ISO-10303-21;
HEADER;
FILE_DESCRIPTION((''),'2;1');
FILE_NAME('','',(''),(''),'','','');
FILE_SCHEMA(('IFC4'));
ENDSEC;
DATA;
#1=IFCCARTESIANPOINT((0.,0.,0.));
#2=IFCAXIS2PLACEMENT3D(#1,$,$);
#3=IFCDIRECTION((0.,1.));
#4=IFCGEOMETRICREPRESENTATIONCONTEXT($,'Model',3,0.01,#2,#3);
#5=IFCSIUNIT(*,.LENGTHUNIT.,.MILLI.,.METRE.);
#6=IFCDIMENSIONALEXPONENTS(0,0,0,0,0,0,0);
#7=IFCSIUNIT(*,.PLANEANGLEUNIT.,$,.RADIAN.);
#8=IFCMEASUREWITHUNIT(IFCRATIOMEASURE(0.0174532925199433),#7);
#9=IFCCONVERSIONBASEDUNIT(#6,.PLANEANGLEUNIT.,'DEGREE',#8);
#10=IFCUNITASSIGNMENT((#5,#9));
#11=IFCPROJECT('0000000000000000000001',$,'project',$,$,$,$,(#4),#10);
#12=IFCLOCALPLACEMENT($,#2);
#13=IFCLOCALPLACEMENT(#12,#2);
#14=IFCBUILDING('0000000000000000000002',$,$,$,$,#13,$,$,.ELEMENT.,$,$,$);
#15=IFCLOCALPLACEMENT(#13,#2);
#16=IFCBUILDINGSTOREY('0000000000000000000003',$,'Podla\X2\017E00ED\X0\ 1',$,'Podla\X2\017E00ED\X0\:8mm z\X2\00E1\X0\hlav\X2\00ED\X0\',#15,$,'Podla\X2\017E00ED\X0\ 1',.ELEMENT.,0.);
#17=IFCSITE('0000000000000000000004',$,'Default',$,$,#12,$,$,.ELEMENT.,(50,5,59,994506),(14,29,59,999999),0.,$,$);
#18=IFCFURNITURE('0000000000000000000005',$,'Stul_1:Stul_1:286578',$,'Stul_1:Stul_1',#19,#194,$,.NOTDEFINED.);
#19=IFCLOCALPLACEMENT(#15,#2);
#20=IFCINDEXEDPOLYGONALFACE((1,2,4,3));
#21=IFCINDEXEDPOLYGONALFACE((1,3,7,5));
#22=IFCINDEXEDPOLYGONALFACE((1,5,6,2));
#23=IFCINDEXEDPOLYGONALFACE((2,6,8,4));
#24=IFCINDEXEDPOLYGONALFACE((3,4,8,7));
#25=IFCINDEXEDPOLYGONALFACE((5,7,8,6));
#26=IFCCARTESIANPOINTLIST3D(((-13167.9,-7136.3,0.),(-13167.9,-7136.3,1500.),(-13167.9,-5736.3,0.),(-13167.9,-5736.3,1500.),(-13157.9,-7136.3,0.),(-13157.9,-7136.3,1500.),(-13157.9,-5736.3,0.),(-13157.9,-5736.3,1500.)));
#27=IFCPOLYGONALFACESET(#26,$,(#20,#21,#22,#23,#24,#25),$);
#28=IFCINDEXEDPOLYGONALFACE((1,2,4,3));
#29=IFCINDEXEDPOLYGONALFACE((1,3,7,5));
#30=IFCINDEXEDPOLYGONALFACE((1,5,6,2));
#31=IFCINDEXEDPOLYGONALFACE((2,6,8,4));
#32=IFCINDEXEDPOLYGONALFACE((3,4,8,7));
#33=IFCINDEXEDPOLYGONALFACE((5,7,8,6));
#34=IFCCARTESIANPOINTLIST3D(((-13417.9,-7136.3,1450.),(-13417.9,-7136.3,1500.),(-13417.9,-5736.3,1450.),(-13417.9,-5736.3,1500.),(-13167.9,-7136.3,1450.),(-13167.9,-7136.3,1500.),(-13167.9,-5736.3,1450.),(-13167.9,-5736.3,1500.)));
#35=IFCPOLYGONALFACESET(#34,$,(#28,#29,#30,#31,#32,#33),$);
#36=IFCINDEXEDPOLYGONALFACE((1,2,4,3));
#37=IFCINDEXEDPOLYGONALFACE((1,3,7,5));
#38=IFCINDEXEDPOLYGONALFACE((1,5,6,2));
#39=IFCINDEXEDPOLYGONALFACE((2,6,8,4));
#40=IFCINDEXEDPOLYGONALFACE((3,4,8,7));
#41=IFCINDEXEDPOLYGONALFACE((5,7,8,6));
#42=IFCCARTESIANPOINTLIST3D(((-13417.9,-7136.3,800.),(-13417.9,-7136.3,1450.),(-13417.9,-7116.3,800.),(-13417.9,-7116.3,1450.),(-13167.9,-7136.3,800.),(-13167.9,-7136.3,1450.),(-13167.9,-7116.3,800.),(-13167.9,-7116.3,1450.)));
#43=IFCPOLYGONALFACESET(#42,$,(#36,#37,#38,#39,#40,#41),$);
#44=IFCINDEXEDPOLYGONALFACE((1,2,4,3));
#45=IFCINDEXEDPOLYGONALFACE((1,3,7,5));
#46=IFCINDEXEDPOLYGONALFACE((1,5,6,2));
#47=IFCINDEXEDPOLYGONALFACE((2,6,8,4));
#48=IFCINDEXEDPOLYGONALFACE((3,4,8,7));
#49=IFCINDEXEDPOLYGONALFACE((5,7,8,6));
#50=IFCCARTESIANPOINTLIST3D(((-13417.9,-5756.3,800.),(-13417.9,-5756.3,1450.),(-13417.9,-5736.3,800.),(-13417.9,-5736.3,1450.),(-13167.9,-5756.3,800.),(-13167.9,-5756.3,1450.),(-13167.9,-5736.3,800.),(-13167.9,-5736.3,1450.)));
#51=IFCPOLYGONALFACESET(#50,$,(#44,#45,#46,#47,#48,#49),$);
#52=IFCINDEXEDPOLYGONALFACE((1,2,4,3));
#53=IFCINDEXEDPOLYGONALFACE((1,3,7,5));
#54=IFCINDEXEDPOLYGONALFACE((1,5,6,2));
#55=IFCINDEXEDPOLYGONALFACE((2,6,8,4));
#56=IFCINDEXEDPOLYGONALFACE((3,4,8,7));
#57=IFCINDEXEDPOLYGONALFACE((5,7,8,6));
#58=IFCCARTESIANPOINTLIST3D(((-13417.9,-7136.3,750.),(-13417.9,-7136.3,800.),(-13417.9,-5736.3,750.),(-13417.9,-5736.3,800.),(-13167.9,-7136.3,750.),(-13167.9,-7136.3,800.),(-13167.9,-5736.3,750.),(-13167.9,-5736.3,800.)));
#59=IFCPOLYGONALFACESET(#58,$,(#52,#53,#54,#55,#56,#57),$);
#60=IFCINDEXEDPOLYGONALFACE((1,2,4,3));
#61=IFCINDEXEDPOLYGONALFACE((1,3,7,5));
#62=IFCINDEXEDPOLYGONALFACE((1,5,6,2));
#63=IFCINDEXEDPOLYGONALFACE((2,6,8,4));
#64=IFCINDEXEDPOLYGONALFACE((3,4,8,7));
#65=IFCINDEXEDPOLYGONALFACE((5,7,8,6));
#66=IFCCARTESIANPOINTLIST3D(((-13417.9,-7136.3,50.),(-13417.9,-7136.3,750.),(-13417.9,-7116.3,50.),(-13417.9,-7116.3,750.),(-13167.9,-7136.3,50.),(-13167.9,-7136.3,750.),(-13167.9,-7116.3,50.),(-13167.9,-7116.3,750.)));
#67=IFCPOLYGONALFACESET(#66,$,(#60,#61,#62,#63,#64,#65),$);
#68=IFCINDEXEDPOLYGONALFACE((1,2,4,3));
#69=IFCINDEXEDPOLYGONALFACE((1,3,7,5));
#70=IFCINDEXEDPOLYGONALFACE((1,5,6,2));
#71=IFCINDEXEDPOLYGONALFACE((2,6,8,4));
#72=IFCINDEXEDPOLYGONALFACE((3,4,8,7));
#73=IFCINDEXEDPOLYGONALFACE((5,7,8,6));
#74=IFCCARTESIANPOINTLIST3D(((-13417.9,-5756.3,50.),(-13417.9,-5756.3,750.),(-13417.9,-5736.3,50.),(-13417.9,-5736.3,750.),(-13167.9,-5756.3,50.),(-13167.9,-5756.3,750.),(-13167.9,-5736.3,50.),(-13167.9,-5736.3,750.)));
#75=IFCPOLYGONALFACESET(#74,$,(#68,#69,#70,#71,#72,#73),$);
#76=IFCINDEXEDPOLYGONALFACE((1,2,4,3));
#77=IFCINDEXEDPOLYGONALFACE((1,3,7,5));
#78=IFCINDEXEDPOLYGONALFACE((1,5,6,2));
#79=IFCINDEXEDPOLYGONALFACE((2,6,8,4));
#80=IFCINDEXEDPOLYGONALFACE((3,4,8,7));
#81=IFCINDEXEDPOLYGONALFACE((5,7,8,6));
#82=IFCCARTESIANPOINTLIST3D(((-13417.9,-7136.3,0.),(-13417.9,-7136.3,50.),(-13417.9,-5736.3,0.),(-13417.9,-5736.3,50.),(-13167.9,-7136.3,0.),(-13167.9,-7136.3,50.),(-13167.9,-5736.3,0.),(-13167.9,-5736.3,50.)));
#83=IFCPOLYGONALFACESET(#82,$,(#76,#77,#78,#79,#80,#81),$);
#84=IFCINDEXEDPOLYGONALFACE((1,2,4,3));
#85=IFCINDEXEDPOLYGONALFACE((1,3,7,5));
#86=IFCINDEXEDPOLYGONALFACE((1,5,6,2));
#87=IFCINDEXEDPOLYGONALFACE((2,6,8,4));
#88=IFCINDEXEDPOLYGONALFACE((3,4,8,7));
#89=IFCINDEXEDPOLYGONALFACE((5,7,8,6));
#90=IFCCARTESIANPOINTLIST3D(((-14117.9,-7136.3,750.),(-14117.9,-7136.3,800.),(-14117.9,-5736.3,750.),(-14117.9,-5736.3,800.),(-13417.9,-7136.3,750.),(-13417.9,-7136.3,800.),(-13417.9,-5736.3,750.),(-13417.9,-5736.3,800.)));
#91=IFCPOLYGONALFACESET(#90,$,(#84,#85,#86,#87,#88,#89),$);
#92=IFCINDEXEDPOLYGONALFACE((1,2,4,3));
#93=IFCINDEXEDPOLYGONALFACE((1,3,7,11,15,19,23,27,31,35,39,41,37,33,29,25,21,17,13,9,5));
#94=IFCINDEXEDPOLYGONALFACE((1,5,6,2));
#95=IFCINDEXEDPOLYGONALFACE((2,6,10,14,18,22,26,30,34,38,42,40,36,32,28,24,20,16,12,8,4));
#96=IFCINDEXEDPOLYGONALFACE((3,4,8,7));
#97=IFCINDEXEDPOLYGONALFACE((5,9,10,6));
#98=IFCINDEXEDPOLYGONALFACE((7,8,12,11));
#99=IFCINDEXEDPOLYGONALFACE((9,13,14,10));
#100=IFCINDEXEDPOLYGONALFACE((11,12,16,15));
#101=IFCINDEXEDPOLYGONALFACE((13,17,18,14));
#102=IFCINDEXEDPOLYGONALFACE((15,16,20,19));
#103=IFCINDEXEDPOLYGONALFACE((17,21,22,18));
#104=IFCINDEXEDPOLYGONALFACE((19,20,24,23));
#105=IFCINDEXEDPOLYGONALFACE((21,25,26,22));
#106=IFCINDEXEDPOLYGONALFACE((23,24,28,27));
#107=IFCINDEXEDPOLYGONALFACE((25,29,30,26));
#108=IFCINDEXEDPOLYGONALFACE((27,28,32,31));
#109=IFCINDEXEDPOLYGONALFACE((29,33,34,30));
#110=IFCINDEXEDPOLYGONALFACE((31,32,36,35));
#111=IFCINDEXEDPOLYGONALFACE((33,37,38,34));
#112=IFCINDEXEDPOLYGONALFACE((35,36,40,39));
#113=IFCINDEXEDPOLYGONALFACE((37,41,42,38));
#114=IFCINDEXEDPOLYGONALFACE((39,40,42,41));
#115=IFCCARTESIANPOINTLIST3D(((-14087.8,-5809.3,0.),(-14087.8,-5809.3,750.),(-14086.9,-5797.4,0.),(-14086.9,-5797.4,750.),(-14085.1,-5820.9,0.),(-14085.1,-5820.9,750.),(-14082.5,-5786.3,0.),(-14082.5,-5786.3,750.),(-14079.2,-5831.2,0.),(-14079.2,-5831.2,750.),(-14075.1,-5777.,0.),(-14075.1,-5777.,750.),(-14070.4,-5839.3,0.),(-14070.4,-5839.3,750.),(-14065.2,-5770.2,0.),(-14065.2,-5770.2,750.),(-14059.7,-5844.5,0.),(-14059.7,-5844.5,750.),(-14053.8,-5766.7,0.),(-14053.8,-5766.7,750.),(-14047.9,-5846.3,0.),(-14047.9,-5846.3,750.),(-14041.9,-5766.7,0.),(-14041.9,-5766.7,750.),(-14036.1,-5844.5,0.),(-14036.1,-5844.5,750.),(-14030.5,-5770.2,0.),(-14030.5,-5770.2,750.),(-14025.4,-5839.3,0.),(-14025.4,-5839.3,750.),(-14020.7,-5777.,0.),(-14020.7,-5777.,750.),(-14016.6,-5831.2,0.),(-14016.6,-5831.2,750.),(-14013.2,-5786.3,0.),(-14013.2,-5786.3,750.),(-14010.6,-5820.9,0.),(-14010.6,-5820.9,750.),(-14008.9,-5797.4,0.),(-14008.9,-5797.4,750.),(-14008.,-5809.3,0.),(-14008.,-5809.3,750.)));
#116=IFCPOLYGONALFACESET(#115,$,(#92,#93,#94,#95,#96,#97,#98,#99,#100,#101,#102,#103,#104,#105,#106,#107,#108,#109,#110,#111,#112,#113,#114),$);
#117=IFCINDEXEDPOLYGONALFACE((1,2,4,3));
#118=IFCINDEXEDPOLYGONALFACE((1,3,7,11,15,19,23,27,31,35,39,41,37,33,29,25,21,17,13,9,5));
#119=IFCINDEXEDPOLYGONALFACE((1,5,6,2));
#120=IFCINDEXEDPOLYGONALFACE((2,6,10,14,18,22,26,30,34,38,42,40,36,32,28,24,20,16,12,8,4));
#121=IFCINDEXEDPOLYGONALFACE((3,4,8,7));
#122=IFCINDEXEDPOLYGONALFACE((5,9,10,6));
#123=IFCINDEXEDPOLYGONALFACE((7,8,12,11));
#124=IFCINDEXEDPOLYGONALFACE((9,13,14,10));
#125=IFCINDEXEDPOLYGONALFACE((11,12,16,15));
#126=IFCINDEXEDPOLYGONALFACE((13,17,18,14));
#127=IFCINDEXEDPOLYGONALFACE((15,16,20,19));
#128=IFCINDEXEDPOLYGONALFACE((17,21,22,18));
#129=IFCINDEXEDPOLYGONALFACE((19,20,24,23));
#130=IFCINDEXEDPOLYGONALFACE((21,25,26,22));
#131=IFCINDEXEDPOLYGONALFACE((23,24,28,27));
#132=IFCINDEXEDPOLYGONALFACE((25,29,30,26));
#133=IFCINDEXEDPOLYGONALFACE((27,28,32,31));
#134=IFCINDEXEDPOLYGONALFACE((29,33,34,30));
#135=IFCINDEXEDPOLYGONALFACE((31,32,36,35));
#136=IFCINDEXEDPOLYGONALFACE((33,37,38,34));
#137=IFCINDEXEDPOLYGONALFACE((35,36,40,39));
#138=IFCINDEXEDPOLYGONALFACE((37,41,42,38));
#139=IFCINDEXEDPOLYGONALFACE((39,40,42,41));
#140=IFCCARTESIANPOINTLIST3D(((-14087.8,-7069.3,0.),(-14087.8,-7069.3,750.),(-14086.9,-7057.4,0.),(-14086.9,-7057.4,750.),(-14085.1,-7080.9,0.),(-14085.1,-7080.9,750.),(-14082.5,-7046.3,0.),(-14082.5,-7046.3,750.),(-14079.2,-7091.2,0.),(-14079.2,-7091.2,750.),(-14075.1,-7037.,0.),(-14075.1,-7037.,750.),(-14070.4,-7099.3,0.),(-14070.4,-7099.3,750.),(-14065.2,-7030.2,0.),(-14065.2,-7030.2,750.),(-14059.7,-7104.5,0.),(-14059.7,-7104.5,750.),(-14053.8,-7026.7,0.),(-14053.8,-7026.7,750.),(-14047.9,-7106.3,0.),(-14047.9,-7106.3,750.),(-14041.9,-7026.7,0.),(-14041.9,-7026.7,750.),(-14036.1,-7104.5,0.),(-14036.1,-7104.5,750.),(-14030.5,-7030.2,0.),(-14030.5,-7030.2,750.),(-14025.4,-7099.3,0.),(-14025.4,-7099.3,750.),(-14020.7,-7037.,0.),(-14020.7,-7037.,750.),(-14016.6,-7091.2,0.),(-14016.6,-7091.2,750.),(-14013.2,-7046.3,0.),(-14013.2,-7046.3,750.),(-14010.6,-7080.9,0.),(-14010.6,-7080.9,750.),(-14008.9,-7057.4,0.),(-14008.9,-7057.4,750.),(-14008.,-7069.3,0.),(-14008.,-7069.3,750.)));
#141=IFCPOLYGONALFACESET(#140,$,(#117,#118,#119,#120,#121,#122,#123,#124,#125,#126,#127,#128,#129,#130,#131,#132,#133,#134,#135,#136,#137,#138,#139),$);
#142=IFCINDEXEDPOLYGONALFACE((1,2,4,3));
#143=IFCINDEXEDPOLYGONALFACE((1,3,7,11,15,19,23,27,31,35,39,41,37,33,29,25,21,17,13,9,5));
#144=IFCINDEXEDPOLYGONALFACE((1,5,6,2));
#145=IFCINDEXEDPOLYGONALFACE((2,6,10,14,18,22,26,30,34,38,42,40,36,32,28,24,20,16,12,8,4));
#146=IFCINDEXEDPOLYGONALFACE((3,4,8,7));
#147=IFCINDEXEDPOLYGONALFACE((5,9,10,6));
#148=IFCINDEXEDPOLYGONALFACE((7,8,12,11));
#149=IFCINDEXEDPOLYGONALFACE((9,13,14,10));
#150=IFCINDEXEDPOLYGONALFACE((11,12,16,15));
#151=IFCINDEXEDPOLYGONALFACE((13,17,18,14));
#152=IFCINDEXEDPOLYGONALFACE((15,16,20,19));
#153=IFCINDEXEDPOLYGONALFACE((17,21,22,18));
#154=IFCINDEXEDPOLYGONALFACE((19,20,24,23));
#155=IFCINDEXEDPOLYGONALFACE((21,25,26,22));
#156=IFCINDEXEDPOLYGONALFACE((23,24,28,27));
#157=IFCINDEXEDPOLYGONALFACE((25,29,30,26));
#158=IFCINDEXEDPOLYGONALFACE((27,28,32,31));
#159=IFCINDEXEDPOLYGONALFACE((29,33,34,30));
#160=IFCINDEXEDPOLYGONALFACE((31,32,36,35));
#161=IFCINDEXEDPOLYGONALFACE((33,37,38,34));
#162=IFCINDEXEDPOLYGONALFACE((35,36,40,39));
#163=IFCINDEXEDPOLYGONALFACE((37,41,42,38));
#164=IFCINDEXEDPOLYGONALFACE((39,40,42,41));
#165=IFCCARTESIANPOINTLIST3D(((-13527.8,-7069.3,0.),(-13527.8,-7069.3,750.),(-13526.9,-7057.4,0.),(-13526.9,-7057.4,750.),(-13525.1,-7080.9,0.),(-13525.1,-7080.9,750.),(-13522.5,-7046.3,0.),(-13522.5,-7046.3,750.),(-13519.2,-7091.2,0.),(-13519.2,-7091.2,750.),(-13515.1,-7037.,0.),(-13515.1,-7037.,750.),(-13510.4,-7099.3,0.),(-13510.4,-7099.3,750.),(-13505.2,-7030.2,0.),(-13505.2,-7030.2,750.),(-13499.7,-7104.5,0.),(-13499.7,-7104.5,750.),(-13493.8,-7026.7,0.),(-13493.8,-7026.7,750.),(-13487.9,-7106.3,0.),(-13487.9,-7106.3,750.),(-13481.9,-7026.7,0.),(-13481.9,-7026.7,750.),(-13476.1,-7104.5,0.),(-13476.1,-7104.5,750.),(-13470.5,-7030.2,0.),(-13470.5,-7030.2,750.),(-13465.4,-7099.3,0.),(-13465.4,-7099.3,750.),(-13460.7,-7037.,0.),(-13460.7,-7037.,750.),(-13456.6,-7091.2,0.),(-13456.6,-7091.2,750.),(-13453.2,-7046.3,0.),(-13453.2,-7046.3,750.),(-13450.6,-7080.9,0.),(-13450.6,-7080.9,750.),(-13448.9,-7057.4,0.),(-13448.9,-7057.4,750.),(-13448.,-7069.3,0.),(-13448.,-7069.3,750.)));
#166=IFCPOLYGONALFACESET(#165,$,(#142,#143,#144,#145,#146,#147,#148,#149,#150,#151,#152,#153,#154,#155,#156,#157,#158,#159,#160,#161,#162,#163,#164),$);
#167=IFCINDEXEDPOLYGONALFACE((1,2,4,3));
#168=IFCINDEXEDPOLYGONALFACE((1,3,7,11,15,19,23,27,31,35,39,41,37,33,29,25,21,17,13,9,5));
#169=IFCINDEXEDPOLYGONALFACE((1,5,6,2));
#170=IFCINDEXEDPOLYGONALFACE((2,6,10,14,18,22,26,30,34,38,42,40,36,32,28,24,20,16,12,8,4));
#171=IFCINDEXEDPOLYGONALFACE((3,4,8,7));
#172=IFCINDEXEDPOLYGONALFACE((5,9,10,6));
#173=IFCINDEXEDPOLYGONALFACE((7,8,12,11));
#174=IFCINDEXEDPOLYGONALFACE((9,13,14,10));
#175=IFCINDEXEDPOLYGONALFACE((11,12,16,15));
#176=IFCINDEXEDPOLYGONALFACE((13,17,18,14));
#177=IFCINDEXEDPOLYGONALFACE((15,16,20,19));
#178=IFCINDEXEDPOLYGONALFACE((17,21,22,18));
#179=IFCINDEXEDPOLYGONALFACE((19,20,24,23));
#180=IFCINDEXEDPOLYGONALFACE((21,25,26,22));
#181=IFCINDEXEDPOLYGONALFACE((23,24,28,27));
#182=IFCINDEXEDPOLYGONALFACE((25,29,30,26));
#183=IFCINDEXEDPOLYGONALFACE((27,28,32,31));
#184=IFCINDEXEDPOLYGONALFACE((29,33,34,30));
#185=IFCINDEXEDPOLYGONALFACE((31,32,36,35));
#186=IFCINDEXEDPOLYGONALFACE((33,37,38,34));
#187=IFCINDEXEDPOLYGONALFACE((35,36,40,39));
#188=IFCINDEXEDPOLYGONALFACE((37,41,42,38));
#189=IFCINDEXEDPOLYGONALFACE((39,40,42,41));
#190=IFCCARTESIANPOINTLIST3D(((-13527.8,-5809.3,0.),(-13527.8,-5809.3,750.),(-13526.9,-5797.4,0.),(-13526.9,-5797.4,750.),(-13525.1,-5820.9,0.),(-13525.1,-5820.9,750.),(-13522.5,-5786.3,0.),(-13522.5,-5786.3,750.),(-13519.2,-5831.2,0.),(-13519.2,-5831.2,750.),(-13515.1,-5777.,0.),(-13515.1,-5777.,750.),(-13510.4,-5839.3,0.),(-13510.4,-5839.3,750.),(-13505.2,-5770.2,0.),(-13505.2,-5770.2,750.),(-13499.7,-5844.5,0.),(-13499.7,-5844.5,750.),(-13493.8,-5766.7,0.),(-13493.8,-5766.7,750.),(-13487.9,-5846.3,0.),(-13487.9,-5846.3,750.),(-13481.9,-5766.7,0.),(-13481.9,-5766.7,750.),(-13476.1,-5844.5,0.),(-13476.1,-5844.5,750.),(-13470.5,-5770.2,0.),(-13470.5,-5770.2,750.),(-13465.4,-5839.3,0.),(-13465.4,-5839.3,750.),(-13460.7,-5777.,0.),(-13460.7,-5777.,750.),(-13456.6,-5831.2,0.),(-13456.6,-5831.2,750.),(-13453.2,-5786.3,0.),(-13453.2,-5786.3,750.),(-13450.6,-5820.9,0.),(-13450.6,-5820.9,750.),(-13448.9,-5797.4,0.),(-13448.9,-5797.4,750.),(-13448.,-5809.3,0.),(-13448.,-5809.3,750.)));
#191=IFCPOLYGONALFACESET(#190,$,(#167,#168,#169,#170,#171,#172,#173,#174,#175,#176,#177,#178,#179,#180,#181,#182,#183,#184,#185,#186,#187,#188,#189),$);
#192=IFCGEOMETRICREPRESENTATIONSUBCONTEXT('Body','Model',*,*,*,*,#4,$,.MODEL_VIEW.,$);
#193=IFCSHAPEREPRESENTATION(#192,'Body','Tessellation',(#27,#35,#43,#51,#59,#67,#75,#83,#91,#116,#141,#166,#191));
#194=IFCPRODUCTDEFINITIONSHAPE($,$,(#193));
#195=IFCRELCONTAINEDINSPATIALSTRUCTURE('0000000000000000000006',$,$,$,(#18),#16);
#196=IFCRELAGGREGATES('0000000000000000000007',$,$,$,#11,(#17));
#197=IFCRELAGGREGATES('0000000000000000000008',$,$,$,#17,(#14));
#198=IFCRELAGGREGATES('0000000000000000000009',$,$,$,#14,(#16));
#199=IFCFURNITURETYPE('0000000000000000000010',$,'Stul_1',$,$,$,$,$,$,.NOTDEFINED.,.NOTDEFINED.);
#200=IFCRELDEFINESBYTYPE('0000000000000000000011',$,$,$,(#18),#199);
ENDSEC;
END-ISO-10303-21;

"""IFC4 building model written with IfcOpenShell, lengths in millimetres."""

from ifc_helpers import new_model, entity, si_unit, converted_unit, direction, frame, frame_2d, origin, origin_2d_with_axis, place, context, subcontext, project, spatial, rectangle, circle, extrude, source, transform, mapped, type_object, type_shapes, element, save


model = new_model("IFC4")

# Units and contexts
model_context = context("Model", 3, precision=0.01, world=origin(), true_north=direction((0.0, 1.0)))
body_context = subcontext(model_context, "Body", "Model", "MODEL_VIEW")
ifc_project = project(units=[si_unit("LENGTHUNIT", "METRE", prefix="MILLI"), converted_unit("PLANEANGLEUNIT", "DEGREE", entity("IfcRatioMeasure", 0.0174532925199433), si_unit("PLANEANGLEUNIT", "RADIAN"), dimensions=[0, 0, 0, 0, 0, 0, 0])], contexts=[model_context])

# Site, building, storey
site_placement = place(None, origin())
site = spatial("IfcSite", under=ifc_project, at=site_placement, Name="Default", CompositionType="ELEMENT", RefLatitude=(50, 5, 59, 994506), RefLongitude=(14, 29, 59, 999999), RefElevation=0.0)
building_placement = place(site_placement, origin())
building = spatial("IfcBuilding", under=site, at=building_placement, CompositionType="ELEMENT")
storey_placement = place(building_placement, origin())
storey = spatial("IfcBuildingStorey", under=building, at=storey_placement, Name="Podlaží 1", ObjectType="Podlaží:8mm záhlaví", LongName="Podlaží 1", CompositionType="ELEMENT", Elevation=0.0)

# Furniture
furniture_type = type_object("IfcFurnitureType", Name="Stul_1", AssemblyPlace="NOTDEFINED", PredefinedType="NOTDEFINED")
shared_shape_1 = source(origin(), body_context, "Body", "SweptSolid", [
    extrude(rectangle(XDim=1400.0, YDim=10.0, at=origin_2d_with_axis()), frame((0.0, 605.0, 0.0), z_axis=(0.0, 0.0, 1.0), x_axis=(-1.0, 0.0, 0.0)), (0.0, 0.0, 1.0), 1500.0),
    extrude(rectangle(XDim=1400.0, YDim=250.0, at=frame_2d((0.0, 0.0), x_axis=(1.0, 0.0))), frame((0.0, 475.0, 1450.0), z_axis=(0.0, 0.0, 1.0), x_axis=(-1.0, 0.0, 0.0)), (0.0, 0.0, 1.0), 50.0),
    extrude(rectangle(XDim=20.0, YDim=250.0, at=origin_2d_with_axis()), frame((690.0, 475.0, 800.0), z_axis=(0.0, 0.0, 1.0), x_axis=(-1.0, 0.0, 0.0)), (0.0, 0.0, 1.0), 650.0),
    extrude(rectangle(XDim=20.0, YDim=250.0, at=frame_2d((0.0, 0.0), x_axis=(1.0, 0.0))), frame((-690.0, 475.0, 800.0), z_axis=(0.0, 0.0, 1.0), x_axis=(-1.0, 0.0, 0.0)), (0.0, 0.0, 1.0), 650.0),
    extrude(rectangle(XDim=1400.0, YDim=250.0, at=origin_2d_with_axis()), frame((0.0, 475.0, 750.0), z_axis=(0.0, 0.0, 1.0), x_axis=(-1.0, 0.0, 0.0)), (0.0, 0.0, 1.0), 50.0),
    extrude(rectangle(XDim=20.0, YDim=250.0, at=origin_2d_with_axis()), frame((690.0, 475.0, 50.0), z_axis=(0.0, 0.0, 1.0), x_axis=(-1.0, 0.0, 0.0)), (0.0, 0.0, 1.0), 700.0),
    extrude(rectangle(XDim=20.0, YDim=250.0, at=frame_2d((0.0, 0.0), x_axis=(1.0, 0.0))), frame((-690.0, 475.0, 50.0), z_axis=(0.0, 0.0, 1.0), x_axis=(-1.0, 0.0, 0.0)), (0.0, 0.0, 1.0), 700.0),
    extrude(rectangle(XDim=1400.0, YDim=250.0, at=origin_2d_with_axis()), frame((0.0, 475.0, 0.0), z_axis=(0.0, 0.0, 1.0), x_axis=(-1.0, 0.0, 0.0)), (0.0, 0.0, 1.0), 50.0),
    extrude(rectangle(XDim=1400.0, YDim=700.0, at=origin_2d_with_axis()), frame((0.0, 0.0, 750.0), z_axis=(0.0, 0.0, 1.0), x_axis=(-1.0, 0.0, 0.0)), (0.0, 0.0, 1.0), 50.0),
    extrude(circle(Radius=40.0, at=frame_2d((0.0, 0.0), x_axis=(1.0, 0.0))), frame((-630.0, -280.0, 0.0)), (0.0, 0.0, 1.0), 750.0),
    extrude(circle(Radius=40.0, at=frame_2d((0.0, 0.0), x_axis=(1.0, 0.0))), frame((630.0, -280.0, 0.0)), (0.0, 0.0, 1.0), 750.0),
    extrude(circle(Radius=40.0, at=frame_2d((0.0, 0.0), x_axis=(1.0, 0.0))), frame((630.0, 280.0, 0.0)), (0.0, 0.0, 1.0), 750.0),
    extrude(circle(Radius=40.0, at=frame_2d((0.0, 0.0), x_axis=(1.0, 0.0))), frame((-630.0, 280.0, 0.0)), (0.0, 0.0, 1.0), 750.0),
])
type_shapes(furniture_type, [shared_shape_1])
for number, where, z_axis, x_axis, name in (
    (1, (-13767.9, -6436.3, 0.0), (0.0, 0.0, 1.0), (0.0, -1.0, 0.0), "Stul_1:Stul_1:286578"),
):
    element("IfcFurniture", number, at=place(storey_placement, frame(where, z_axis=z_axis, x_axis=x_axis)), inside=storey, type_object=furniture_type, Name=name, ObjectType="Stul_1:Stul_1", PredefinedType="NOTDEFINED", context=body_context, shape_type="MappedRepresentation", body=[
        mapped(shared_shape_1, transform((0.0, 0.0, 0.0), scale=1.0)),
    ])

save(model, "model.ifc")
